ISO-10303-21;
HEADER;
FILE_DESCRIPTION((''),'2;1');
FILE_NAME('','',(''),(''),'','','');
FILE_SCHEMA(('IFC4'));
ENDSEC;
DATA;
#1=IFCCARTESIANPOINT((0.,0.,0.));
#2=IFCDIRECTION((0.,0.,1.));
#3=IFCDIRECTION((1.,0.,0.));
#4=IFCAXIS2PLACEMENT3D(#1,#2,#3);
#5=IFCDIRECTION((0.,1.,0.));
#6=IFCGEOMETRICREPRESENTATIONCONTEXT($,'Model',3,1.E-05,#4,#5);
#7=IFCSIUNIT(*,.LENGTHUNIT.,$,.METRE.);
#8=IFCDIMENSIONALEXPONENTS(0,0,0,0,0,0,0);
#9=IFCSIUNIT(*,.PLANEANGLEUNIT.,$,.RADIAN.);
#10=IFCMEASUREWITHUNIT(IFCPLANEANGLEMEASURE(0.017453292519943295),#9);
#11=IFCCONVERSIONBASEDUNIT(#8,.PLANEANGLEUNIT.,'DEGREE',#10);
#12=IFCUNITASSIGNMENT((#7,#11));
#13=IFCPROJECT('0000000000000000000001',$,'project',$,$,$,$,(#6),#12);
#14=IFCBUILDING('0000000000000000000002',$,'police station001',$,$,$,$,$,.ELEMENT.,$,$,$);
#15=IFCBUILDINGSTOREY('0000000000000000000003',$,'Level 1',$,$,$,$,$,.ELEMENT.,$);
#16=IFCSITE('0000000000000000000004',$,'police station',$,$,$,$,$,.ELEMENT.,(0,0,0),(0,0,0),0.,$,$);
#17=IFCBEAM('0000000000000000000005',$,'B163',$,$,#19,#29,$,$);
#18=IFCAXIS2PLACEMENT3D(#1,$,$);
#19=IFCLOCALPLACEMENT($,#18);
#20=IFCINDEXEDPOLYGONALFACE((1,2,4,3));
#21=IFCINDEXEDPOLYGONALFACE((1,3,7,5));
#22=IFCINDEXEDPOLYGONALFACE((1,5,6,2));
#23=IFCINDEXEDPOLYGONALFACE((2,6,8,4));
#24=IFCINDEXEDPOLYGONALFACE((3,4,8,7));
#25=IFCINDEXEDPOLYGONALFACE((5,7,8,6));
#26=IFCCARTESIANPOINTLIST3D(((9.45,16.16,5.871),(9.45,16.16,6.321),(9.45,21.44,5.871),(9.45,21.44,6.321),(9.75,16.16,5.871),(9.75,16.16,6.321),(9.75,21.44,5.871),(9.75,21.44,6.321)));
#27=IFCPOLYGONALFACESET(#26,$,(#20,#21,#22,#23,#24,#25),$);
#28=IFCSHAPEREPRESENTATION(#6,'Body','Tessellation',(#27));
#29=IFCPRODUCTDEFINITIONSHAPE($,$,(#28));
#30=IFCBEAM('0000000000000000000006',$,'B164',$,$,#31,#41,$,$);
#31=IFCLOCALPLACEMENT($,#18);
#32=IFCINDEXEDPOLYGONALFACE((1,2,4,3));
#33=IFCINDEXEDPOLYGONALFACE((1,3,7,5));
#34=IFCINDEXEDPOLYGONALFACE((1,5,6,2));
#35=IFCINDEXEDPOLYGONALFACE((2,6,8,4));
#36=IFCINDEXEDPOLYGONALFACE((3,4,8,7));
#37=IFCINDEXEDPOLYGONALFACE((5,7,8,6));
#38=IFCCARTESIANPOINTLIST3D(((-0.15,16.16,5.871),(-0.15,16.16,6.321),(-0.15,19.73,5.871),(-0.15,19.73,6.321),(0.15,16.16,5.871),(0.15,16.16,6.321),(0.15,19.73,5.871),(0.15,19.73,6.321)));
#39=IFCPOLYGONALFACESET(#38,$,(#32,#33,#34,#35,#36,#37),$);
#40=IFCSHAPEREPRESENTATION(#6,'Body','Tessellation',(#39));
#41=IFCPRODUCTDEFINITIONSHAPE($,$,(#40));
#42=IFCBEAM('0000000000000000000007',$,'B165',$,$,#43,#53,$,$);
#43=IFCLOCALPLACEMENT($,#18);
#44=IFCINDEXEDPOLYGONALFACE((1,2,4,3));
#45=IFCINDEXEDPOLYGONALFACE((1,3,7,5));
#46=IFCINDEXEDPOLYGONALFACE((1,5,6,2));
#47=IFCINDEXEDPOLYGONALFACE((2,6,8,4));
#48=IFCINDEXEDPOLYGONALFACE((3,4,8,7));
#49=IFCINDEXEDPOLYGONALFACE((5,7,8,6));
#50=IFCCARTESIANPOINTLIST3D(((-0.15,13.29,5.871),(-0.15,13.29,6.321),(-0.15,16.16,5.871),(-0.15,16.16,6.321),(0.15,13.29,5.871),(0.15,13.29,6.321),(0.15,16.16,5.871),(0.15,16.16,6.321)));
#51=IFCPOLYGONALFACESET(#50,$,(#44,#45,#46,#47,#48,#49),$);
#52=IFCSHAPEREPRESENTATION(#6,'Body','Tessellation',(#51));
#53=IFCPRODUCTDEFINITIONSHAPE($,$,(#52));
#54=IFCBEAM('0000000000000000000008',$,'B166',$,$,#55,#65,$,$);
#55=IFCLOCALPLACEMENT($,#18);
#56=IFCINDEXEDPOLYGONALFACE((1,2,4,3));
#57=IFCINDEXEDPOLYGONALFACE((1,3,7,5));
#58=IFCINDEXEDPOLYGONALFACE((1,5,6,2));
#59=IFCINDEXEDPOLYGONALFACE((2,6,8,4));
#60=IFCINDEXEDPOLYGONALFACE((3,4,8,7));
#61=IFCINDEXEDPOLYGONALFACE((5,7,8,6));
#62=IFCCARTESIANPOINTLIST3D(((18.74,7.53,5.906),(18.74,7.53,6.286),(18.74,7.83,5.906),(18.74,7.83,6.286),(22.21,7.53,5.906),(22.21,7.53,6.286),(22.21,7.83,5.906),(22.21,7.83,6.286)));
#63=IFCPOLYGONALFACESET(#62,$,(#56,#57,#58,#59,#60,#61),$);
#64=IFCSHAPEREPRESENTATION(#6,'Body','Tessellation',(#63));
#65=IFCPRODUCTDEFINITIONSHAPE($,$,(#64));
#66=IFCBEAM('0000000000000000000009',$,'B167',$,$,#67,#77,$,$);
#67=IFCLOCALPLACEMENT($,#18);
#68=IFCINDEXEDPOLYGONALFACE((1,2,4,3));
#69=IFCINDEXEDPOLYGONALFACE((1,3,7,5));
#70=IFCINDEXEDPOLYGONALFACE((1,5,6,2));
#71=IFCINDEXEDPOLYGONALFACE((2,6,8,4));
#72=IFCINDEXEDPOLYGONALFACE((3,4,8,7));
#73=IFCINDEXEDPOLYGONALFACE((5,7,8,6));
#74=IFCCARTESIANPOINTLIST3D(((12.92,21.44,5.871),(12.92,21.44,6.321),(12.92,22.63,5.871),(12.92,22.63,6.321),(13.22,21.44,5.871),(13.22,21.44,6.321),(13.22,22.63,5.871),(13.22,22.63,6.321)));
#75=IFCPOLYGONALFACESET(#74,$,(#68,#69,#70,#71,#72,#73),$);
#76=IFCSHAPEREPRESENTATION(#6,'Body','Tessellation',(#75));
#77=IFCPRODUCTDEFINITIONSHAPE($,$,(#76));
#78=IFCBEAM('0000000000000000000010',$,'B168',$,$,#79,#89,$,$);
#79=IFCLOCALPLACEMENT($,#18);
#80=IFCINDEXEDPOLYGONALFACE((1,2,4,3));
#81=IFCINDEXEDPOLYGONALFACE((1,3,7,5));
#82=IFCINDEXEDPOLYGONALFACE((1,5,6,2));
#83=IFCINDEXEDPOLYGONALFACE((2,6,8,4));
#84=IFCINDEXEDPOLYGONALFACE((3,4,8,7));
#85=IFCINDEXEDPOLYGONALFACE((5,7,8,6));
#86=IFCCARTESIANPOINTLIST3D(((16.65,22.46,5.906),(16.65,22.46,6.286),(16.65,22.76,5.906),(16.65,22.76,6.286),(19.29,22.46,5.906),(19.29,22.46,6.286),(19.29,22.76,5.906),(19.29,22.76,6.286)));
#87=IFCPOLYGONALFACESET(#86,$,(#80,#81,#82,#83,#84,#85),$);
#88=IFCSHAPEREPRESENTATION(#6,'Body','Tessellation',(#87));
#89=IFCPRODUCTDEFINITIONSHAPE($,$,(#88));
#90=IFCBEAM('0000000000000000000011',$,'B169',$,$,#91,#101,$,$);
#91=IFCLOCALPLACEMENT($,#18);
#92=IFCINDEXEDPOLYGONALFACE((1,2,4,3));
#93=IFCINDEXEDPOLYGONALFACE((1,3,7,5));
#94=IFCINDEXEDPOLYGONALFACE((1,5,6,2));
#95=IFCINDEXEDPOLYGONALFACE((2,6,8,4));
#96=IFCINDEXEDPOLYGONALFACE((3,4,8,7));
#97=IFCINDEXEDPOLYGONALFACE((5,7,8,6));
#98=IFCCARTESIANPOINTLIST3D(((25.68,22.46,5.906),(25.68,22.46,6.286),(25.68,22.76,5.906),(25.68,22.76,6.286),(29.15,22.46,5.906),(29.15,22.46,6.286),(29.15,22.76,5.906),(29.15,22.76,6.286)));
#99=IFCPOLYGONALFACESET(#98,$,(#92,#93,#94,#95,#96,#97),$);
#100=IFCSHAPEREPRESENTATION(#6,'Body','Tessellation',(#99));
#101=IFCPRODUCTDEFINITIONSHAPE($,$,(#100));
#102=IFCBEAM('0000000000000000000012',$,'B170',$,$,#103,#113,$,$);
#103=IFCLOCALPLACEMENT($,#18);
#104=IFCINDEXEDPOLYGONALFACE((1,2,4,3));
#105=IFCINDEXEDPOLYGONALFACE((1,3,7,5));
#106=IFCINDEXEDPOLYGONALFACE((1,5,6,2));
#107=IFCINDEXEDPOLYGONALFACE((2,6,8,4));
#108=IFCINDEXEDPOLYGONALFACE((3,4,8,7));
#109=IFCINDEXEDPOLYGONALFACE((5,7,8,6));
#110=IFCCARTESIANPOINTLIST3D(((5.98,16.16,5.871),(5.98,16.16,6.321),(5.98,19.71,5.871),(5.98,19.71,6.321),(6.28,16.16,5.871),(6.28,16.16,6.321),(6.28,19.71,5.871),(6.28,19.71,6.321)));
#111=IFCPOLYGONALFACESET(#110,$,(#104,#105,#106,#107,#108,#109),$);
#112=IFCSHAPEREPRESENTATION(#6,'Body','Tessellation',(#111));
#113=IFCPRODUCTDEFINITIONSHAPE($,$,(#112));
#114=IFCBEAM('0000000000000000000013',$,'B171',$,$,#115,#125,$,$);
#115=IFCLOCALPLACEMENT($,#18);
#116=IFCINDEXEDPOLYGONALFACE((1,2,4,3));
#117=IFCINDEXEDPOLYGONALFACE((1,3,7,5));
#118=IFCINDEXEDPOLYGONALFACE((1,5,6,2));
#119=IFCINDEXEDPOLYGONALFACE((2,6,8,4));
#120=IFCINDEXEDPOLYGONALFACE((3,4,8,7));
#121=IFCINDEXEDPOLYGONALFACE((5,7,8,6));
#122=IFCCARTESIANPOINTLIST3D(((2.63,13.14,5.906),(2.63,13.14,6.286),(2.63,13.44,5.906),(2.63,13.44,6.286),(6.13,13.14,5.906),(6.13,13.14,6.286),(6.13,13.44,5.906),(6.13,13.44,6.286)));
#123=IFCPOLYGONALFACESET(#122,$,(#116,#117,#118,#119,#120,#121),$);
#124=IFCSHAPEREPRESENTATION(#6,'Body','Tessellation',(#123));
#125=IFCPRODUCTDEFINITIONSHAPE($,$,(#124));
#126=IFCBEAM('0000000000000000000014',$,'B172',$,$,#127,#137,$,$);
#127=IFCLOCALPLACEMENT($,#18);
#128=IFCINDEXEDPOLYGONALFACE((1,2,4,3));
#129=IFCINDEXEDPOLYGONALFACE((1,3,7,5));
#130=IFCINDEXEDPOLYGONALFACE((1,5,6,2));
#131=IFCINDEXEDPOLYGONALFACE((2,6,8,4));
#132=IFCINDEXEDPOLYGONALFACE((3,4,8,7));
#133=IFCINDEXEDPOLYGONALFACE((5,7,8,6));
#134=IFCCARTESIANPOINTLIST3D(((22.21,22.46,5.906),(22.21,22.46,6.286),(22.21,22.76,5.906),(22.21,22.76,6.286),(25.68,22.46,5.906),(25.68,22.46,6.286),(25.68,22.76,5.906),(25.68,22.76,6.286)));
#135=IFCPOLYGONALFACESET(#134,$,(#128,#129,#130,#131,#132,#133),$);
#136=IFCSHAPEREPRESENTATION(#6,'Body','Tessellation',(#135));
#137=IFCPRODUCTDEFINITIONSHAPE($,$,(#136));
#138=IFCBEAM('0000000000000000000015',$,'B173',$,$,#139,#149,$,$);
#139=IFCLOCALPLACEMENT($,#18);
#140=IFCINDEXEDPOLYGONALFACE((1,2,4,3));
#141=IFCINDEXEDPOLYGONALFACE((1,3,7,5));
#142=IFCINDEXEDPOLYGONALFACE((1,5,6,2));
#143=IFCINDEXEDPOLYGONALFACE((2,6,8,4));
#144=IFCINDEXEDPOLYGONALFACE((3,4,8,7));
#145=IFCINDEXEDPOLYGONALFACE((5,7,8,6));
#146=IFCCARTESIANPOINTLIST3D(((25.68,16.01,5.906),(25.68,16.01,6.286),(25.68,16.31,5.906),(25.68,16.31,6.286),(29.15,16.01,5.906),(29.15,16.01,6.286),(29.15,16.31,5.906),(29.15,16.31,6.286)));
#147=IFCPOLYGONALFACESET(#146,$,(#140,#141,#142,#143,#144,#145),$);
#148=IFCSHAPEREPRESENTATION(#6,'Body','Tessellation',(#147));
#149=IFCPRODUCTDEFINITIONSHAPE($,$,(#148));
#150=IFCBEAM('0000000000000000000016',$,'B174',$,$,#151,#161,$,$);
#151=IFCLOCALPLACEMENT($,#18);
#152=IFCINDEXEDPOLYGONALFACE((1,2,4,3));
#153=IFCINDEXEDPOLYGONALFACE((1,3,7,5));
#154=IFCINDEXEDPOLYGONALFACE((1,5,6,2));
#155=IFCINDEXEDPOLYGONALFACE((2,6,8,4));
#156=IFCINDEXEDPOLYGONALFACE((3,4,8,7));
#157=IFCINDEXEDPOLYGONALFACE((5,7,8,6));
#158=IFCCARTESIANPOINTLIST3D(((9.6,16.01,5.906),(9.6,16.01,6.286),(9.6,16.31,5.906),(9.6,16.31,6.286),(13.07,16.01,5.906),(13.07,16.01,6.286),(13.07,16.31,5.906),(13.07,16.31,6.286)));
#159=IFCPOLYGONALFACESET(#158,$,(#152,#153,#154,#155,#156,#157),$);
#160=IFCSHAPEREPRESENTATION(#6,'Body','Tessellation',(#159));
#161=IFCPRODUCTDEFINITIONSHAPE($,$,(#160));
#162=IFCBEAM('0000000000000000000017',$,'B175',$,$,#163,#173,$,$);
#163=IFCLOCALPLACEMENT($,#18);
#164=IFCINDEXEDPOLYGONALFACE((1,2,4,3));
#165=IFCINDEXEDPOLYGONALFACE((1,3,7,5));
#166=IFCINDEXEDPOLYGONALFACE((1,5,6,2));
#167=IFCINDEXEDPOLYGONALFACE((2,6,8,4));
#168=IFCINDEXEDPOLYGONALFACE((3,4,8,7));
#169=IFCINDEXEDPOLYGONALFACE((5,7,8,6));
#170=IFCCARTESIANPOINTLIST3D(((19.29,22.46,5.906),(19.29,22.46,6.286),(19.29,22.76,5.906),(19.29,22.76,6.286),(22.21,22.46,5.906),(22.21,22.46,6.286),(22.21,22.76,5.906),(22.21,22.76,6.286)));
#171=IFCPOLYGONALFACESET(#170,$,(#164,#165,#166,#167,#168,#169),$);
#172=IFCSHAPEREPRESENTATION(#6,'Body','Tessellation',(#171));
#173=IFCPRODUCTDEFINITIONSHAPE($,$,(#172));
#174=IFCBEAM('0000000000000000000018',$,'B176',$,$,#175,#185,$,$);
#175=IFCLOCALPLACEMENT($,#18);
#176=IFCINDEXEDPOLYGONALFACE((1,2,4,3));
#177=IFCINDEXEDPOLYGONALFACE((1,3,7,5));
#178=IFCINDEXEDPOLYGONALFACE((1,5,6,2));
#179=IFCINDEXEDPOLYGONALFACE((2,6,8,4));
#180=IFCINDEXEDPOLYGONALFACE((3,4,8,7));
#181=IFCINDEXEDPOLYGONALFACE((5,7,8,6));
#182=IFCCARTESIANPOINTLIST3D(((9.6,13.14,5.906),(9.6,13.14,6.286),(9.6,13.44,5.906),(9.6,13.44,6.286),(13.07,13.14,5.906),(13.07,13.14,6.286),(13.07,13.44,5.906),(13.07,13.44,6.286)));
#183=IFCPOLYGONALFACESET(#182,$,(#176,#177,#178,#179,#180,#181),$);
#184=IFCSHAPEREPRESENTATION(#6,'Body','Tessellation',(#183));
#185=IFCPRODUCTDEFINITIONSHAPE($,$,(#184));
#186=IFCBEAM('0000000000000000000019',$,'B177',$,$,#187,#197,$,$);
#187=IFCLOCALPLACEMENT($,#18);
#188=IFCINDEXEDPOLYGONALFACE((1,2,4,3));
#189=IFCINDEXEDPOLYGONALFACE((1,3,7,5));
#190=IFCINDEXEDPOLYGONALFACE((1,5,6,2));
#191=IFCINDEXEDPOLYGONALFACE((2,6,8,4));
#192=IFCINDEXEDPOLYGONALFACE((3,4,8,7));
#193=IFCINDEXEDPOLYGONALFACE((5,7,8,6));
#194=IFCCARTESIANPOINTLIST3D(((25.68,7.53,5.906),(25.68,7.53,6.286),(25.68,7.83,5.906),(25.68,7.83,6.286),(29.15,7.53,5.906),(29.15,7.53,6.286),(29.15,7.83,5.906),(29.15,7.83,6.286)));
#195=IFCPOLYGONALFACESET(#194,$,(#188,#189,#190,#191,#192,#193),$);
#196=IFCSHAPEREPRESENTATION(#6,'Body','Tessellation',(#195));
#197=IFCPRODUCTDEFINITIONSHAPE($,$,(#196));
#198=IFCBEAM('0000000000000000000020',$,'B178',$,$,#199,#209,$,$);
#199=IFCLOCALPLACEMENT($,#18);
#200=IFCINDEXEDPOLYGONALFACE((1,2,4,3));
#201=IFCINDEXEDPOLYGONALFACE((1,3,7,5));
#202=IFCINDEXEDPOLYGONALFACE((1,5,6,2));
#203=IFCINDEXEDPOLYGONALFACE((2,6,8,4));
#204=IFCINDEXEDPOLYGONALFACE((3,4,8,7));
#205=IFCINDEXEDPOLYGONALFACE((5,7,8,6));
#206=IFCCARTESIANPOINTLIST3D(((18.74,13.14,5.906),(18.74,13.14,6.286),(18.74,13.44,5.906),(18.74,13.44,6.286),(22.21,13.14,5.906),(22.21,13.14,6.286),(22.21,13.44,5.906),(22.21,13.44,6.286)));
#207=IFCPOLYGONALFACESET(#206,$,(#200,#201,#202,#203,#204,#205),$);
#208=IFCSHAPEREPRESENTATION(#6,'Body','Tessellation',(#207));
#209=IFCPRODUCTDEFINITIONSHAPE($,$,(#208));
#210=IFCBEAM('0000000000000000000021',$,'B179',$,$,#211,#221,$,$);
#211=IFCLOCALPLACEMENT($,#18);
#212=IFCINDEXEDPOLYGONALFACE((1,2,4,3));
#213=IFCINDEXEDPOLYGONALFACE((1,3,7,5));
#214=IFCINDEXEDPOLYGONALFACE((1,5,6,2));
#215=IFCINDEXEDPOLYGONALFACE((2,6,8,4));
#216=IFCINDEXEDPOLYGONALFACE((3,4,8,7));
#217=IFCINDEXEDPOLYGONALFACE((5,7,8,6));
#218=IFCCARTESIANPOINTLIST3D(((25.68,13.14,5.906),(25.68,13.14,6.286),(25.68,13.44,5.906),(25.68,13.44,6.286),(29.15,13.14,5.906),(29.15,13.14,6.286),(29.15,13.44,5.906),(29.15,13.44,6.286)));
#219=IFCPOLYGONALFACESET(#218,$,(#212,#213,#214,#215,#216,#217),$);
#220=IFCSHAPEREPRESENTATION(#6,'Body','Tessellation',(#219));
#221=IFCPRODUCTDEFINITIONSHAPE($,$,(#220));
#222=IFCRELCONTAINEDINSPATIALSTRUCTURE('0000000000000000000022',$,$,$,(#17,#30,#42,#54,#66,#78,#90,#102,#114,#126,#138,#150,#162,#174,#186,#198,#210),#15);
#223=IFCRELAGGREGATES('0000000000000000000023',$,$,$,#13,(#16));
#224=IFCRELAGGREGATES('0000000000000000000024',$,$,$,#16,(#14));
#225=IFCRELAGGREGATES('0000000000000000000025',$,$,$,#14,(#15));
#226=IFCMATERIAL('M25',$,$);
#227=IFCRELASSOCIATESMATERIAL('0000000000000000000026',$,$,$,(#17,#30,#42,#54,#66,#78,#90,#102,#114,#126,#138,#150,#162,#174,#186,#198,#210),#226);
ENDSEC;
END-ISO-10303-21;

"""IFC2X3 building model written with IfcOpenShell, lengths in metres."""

from ifc_helpers import new_model, entity, si_unit, converted_unit, direction, frame, frame_2d, origin_with_axes, place, context, project, spatial, rectangle, extrude, material, element, save


model = new_model("IFC2X3")

# Units and contexts
model_context = context("Model", 3, precision=1e-05, world=origin_with_axes(), true_north=direction((0.0, 1.0, 0.0)))
ifc_project = project(units=[si_unit("LENGTHUNIT", "METRE"), converted_unit("PLANEANGLEUNIT", "DEGREE", entity("IfcPlaneAngleMeasure", 0.017453292519943295), si_unit("PLANEANGLEUNIT", "RADIAN"), dimensions=[0, 0, 0, 0, 0, 0, 0])], contexts=[model_context])

# Site, building, storey
site = spatial("IfcSite", under=ifc_project, Name="police station", CompositionType="ELEMENT", RefLatitude=(0, 0, 0), RefLongitude=(0, 0, 0), RefElevation=0.0)
building = spatial("IfcBuilding", under=site, Name="police station001", CompositionType="ELEMENT")
storey = spatial("IfcBuildingStorey", under=building, Name="Level 1", CompositionType="ELEMENT")

# Beams
ifc_material = material(Name="M25")
placement = place(None, origin_with_axes())
element("IfcBeam", 1, at=placement, inside=storey, material=ifc_material, Name="B163", context=model_context, shape_type="SweptSolid", body=[
    extrude(rectangle(XDim=0.3, YDim=0.45, at=frame_2d((0.0, 0.0), x_axis=(0.0, 1.0, 0.0))), frame((9.6, 16.16, 6.096), z_axis=(0.0, 1.0, 0.0), x_axis=(0.0, 0.0, -1.0)), (0.0, 0.0, 1.0), 5.28),
])
element("IfcBeam", 2, at=placement, inside=storey, material=ifc_material, Name="B164", context=model_context, shape_type="SweptSolid", body=[
    extrude(rectangle(XDim=0.3, YDim=0.45, at=frame_2d((0.0, 0.0), x_axis=(0.0, 1.0, 0.0))), frame((0.0, 19.73, 6.096), z_axis=(0.0, -1.0, 0.0), x_axis=(0.0, 0.0, -1.0)), (0.0, 0.0, 1.0), 3.57),
])
element("IfcBeam", 3, at=placement, inside=storey, material=ifc_material, Name="B165", context=model_context, shape_type="SweptSolid", body=[
    extrude(rectangle(XDim=0.3, YDim=0.45, at=frame_2d((0.0, 0.0), x_axis=(0.0, 1.0, 0.0))), frame((0.0, 13.29, 6.096), z_axis=(0.0, 1.0, 0.0), x_axis=(0.0, 0.0, -1.0)), (0.0, 0.0, 1.0), 2.87),
])
element("IfcBeam", 4, at=placement, inside=storey, material=ifc_material, Name="B166", context=model_context, shape_type="SweptSolid", body=[
    extrude(rectangle(XDim=0.3, YDim=0.38, at=frame_2d((0.0, 0.0), x_axis=(0.0, 1.0, 0.0))), frame((18.74, 7.68, 6.096), z_axis=(1.0, 0.0, 0.0), x_axis=(0.0, 0.0, -1.0)), (0.0, 0.0, 1.0), 3.47),
])
element("IfcBeam", 5, at=placement, inside=storey, material=ifc_material, Name="B167", context=model_context, shape_type="SweptSolid", body=[
    extrude(rectangle(XDim=0.3, YDim=0.45, at=frame_2d((0.0, 0.0), x_axis=(0.0, 1.0, 0.0))), frame((13.07, 21.44, 6.096), z_axis=(0.0, 1.0, 0.0), x_axis=(0.0, 0.0, -1.0)), (0.0, 0.0, 1.0), 1.19),
])
element("IfcBeam", 6, at=placement, inside=storey, material=ifc_material, Name="B168", context=model_context, shape_type="SweptSolid", body=[
    extrude(rectangle(XDim=0.3, YDim=0.38, at=frame_2d((0.0, 0.0), x_axis=(0.0, 1.0, 0.0))), frame((19.29, 22.61, 6.096), z_axis=(-1.0, 0.0, 0.0), x_axis=(0.0, 0.0, -1.0)), (0.0, 0.0, 1.0), 2.64),
])
element("IfcBeam", 7, at=placement, inside=storey, material=ifc_material, Name="B169", context=model_context, shape_type="SweptSolid", body=[
    extrude(rectangle(XDim=0.3, YDim=0.38, at=frame_2d((0.0, 0.0), x_axis=(0.0, 1.0, 0.0))), frame((29.15, 22.61, 6.096), z_axis=(-1.0, 0.0, 0.0), x_axis=(0.0, 0.0, -1.0)), (0.0, 0.0, 1.0), 3.47),
])
element("IfcBeam", 8, at=placement, inside=storey, material=ifc_material, Name="B170", context=model_context, shape_type="SweptSolid", body=[
    extrude(rectangle(XDim=0.3, YDim=0.45, at=frame_2d((0.0, 0.0), x_axis=(0.0, 1.0, 0.0))), frame((6.13, 16.16, 6.096), z_axis=(0.0, 1.0, 0.0), x_axis=(0.0, 0.0, -1.0)), (0.0, 0.0, 1.0), 3.55),
])
element("IfcBeam", 9, at=placement, inside=storey, material=ifc_material, Name="B171", context=model_context, shape_type="SweptSolid", body=[
    extrude(rectangle(XDim=0.3, YDim=0.38, at=frame_2d((0.0, 0.0), x_axis=(0.0, 1.0, 0.0))), frame((2.63, 13.29, 6.096), z_axis=(1.0, 0.0, 0.0), x_axis=(0.0, 0.0, -1.0)), (0.0, 0.0, 1.0), 3.5),
])
element("IfcBeam", 10, at=placement, inside=storey, material=ifc_material, Name="B172", context=model_context, shape_type="SweptSolid", body=[
    extrude(rectangle(XDim=0.3, YDim=0.38, at=frame_2d((0.0, 0.0), x_axis=(0.0, 1.0, 0.0))), frame((25.68, 22.61, 6.096), z_axis=(-1.0, 0.0, 0.0), x_axis=(0.0, 0.0, -1.0)), (0.0, 0.0, 1.0), 3.47),
])
element("IfcBeam", 11, at=placement, inside=storey, material=ifc_material, Name="B173", context=model_context, shape_type="SweptSolid", body=[
    extrude(rectangle(XDim=0.3, YDim=0.38, at=frame_2d((0.0, 0.0), x_axis=(0.0, 1.0, 0.0))), frame((25.68, 16.16, 6.096), z_axis=(1.0, 0.0, 0.0), x_axis=(0.0, 0.0, -1.0)), (0.0, 0.0, 1.0), 3.47),
])
element("IfcBeam", 12, at=placement, inside=storey, material=ifc_material, Name="B174", context=model_context, shape_type="SweptSolid", body=[
    extrude(rectangle(XDim=0.3, YDim=0.38, at=frame_2d((0.0, 0.0), x_axis=(0.0, 1.0, 0.0))), frame((13.07, 16.16, 6.096), z_axis=(-1.0, 0.0, 0.0), x_axis=(0.0, 0.0, -1.0)), (0.0, 0.0, 1.0), 3.47),
])
element("IfcBeam", 13, at=placement, inside=storey, material=ifc_material, Name="B175", context=model_context, shape_type="SweptSolid", body=[
    extrude(rectangle(XDim=0.3, YDim=0.38, at=frame_2d((0.0, 0.0), x_axis=(0.0, 1.0, 0.0))), frame((22.21, 22.61, 6.096), z_axis=(-1.0, 0.0, 0.0), x_axis=(0.0, 0.0, -1.0)), (0.0, 0.0, 1.0), 2.92),
])
element("IfcBeam", 14, at=placement, inside=storey, material=ifc_material, Name="B176", context=model_context, shape_type="SweptSolid", body=[
    extrude(rectangle(XDim=0.3, YDim=0.38, at=frame_2d((0.0, 0.0), x_axis=(0.0, 1.0, 0.0))), frame((13.07, 13.29, 6.096), z_axis=(-1.0, 0.0, 0.0), x_axis=(0.0, 0.0, -1.0)), (0.0, 0.0, 1.0), 3.47),
])
element("IfcBeam", 15, at=placement, inside=storey, material=ifc_material, Name="B177", context=model_context, shape_type="SweptSolid", body=[
    extrude(rectangle(XDim=0.3, YDim=0.38, at=frame_2d((0.0, 0.0), x_axis=(0.0, 1.0, 0.0))), frame((25.68, 7.68, 6.096), z_axis=(1.0, 0.0, 0.0), x_axis=(0.0, 0.0, -1.0)), (0.0, 0.0, 1.0), 3.47),
])
element("IfcBeam", 16, at=placement, inside=storey, material=ifc_material, Name="B178", context=model_context, shape_type="SweptSolid", body=[
    extrude(rectangle(XDim=0.3, YDim=0.38, at=frame_2d((0.0, 0.0), x_axis=(0.0, 1.0, 0.0))), frame((22.21, 13.29, 6.096), z_axis=(-1.0, 0.0, 0.0), x_axis=(0.0, 0.0, -1.0)), (0.0, 0.0, 1.0), 3.47),
])
element("IfcBeam", 17, at=placement, inside=storey, material=ifc_material, Name="B179", context=model_context, shape_type="SweptSolid", body=[
    extrude(rectangle(XDim=0.3, YDim=0.38, at=frame_2d((0.0, 0.0), x_axis=(0.0, 1.0, 0.0))), frame((29.15, 13.29, 6.096), z_axis=(-1.0, 0.0, 0.0), x_axis=(0.0, 0.0, -1.0)), (0.0, 0.0, 1.0), 3.47),
])

save(model, "model.ifc")
